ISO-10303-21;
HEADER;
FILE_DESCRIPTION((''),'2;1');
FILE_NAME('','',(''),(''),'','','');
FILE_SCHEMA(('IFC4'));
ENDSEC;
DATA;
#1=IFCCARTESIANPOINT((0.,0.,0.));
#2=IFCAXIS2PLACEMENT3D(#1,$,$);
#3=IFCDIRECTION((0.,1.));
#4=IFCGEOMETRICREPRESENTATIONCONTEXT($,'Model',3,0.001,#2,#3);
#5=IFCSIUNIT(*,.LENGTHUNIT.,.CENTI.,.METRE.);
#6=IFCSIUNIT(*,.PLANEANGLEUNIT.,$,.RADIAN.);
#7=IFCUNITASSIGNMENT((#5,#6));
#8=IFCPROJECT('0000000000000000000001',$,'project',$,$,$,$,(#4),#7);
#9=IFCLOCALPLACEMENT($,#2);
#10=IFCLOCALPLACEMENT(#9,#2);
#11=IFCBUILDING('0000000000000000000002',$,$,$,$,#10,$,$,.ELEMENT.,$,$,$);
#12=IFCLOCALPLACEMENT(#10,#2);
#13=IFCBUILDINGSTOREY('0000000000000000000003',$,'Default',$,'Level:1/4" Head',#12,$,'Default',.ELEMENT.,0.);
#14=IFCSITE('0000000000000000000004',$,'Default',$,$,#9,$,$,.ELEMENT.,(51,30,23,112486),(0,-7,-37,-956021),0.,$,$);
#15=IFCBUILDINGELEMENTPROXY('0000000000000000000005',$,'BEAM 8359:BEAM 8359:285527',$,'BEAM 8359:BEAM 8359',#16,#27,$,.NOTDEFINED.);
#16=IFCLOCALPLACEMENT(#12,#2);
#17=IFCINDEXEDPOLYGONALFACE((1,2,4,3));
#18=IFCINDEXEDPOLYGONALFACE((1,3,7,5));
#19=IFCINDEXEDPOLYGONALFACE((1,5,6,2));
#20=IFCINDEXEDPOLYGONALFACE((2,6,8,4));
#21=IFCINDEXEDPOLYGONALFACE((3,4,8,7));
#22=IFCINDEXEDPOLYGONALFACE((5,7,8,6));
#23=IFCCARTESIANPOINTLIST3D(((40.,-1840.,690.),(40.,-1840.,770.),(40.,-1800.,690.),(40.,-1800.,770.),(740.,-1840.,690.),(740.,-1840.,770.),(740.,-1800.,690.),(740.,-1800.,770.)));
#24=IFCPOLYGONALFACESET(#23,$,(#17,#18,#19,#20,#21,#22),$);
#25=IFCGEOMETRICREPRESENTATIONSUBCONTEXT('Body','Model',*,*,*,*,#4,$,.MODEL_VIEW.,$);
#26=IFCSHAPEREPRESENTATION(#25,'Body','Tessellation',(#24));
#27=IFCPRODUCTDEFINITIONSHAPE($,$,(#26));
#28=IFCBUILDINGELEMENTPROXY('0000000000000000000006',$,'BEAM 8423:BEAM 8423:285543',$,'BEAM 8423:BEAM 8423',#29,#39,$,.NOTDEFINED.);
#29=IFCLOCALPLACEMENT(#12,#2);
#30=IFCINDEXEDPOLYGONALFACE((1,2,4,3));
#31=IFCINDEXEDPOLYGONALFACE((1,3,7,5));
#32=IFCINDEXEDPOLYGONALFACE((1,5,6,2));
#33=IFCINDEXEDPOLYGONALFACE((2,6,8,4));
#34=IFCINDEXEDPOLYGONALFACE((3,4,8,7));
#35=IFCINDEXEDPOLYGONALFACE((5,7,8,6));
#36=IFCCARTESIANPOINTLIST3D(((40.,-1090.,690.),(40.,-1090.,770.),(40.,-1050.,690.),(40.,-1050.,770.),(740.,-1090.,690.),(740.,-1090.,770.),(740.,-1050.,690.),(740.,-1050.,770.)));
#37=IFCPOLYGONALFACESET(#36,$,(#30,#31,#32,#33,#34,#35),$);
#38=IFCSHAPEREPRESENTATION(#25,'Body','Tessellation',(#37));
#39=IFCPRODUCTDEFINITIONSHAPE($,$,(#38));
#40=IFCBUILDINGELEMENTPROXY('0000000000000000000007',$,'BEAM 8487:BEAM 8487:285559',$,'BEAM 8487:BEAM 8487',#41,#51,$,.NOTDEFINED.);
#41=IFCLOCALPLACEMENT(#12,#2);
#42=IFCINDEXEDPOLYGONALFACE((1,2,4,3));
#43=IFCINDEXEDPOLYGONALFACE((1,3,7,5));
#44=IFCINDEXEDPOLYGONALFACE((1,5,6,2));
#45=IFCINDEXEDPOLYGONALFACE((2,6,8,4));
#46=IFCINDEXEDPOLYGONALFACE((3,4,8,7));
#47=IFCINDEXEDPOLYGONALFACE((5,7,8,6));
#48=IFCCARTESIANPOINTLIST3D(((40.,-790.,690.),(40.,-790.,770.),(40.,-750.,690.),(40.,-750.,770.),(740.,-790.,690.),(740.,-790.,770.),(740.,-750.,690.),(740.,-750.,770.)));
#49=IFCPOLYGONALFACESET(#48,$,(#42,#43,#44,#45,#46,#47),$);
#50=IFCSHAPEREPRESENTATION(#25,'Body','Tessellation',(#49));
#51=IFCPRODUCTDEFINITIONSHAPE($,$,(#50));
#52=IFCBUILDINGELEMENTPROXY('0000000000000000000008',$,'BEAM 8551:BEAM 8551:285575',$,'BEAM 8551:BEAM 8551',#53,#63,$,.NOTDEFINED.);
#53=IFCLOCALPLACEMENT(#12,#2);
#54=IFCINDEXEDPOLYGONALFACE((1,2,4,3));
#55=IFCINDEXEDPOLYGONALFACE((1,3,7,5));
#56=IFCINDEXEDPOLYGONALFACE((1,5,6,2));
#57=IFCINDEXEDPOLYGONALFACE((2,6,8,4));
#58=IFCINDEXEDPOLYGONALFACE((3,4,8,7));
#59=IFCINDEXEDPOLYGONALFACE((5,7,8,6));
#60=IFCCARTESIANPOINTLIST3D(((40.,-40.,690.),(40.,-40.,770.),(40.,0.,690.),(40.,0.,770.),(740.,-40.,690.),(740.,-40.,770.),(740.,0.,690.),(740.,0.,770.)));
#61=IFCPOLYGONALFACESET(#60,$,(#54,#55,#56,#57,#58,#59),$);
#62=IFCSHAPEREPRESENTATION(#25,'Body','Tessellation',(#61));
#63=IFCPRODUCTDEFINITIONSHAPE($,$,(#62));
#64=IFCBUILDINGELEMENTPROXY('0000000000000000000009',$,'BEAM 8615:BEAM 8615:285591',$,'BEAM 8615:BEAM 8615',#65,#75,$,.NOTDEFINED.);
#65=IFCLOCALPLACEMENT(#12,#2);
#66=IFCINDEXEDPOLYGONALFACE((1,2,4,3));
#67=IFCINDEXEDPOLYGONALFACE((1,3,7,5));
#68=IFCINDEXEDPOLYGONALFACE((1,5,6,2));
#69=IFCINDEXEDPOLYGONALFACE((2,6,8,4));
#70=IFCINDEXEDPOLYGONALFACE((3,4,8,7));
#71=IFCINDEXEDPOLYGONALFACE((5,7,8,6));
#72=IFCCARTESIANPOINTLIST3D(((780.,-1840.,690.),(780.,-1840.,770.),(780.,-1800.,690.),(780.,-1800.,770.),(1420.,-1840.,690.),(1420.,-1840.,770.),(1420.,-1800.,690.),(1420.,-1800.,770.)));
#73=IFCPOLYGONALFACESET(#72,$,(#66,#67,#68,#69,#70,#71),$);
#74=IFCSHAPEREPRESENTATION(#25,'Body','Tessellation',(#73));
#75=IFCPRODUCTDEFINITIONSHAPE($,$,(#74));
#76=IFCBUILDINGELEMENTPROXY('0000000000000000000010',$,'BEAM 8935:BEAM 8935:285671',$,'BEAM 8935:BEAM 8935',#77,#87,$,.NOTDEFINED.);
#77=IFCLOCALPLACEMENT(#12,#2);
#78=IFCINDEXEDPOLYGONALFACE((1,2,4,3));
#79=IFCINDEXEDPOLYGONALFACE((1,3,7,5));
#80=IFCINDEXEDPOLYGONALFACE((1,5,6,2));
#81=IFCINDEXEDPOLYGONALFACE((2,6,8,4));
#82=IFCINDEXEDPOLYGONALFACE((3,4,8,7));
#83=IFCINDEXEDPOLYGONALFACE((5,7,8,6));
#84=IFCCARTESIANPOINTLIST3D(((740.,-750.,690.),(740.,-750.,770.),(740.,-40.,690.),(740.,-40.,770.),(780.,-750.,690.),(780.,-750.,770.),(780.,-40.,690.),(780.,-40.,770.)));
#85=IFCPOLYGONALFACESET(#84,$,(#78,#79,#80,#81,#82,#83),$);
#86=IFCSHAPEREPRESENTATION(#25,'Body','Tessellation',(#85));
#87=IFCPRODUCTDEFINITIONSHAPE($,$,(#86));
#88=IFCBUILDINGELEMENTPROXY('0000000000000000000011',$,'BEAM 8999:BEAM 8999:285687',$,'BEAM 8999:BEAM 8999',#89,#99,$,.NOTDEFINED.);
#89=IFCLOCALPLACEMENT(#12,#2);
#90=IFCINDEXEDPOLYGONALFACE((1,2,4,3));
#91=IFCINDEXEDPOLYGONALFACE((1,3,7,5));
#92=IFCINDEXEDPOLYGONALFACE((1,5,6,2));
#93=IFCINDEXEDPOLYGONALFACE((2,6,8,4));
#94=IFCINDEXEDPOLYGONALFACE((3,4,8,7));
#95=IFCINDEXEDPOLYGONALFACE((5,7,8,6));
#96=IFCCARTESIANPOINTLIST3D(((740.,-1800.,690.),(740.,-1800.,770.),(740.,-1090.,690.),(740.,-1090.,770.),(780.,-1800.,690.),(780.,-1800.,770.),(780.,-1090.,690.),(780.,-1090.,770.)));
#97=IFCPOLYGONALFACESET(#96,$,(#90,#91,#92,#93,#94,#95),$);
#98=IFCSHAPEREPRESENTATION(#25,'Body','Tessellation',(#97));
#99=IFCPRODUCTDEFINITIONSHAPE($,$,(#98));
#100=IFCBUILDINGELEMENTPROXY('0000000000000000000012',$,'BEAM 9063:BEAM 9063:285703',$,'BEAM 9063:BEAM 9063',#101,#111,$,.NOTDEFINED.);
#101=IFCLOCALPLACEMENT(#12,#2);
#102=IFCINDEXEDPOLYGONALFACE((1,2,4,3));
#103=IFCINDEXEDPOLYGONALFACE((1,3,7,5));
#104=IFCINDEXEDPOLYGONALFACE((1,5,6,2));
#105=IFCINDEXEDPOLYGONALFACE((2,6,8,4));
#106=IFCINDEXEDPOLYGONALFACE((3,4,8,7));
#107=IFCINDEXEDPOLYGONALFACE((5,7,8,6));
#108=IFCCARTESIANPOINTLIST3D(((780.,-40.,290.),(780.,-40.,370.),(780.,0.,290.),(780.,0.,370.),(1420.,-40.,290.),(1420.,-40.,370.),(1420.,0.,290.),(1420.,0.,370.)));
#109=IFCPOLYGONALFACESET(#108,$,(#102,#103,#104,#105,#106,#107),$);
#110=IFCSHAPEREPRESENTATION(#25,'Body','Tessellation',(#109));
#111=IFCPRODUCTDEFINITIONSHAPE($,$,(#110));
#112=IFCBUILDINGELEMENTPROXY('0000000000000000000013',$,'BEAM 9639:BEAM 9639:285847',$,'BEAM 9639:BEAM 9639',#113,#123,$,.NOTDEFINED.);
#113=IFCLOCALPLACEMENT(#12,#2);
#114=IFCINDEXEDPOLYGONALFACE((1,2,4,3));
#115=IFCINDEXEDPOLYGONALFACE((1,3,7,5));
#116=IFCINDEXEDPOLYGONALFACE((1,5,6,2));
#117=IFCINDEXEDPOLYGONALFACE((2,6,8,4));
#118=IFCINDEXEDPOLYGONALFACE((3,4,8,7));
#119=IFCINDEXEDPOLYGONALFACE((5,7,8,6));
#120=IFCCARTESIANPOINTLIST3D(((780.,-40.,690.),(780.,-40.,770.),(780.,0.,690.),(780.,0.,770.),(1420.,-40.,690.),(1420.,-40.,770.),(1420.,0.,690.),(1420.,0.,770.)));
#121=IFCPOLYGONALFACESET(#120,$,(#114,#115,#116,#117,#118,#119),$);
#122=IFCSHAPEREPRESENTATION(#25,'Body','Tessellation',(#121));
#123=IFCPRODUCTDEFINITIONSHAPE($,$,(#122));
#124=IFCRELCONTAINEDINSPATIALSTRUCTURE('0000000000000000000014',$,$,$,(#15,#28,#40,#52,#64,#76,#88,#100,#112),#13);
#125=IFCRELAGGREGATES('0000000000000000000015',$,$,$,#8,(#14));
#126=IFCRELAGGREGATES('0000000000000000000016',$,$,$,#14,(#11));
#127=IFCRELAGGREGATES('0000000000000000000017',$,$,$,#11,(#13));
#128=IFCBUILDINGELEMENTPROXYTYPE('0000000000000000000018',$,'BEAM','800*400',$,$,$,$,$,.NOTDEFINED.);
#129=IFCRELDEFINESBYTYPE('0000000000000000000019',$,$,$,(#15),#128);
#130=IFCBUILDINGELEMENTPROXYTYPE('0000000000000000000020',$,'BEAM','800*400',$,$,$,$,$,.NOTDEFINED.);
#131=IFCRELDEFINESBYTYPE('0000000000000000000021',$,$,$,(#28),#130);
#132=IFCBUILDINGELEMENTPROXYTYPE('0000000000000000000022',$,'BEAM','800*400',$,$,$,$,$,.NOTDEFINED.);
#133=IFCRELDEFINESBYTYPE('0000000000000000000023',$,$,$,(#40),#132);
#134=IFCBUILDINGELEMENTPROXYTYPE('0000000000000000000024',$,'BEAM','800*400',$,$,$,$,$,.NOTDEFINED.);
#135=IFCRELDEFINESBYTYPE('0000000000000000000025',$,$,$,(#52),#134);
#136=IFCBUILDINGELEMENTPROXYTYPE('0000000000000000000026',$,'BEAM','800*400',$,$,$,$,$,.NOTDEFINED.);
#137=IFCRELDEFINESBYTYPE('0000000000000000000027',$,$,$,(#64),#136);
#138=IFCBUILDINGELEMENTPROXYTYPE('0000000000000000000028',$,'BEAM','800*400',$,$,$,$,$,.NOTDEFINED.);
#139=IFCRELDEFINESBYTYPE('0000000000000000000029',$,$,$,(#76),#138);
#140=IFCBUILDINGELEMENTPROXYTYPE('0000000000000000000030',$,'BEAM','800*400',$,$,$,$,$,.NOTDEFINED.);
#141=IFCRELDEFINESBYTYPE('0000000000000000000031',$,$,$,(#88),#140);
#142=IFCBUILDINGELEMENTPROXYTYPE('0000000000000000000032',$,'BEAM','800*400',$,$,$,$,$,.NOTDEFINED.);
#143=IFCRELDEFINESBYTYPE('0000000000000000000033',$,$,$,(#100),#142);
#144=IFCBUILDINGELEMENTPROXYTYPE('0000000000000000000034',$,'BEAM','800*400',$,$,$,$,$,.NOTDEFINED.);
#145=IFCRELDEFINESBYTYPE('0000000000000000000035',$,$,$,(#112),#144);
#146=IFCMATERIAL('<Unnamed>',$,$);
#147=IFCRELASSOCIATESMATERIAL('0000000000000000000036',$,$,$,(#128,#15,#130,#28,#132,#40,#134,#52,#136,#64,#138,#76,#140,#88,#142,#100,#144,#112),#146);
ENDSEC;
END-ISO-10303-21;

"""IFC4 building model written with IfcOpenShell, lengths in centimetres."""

from ifc_helpers import new_model, si_unit, direction, frame, origin, origin_2d_with_axis, place, context, subcontext, project, spatial, rectangle, extrude, source, transform, mapped, material, type_object, type_shapes, element, save


model = new_model("IFC4")

# Units and contexts
model_context = context("Model", 3, precision=0.001, world=origin(), true_north=direction((0.0, 1.0)))
body_context = subcontext(model_context, "Body", "Model", "MODEL_VIEW")
ifc_project = project(units=[si_unit("LENGTHUNIT", "METRE", prefix="CENTI"), si_unit("PLANEANGLEUNIT", "RADIAN")], contexts=[model_context])

# Site, building, storey
site_placement = place(None, origin())
site = spatial("IfcSite", under=ifc_project, at=site_placement, Name="Default", CompositionType="ELEMENT", RefLatitude=(51, 30, 23, 112486), RefLongitude=(0, -7, -37, -956021), RefElevation=0.0)
building_placement = place(site_placement, origin())
building = spatial("IfcBuilding", under=site, at=building_placement, CompositionType="ELEMENT")
storey_placement = place(building_placement, origin())
storey = spatial("IfcBuildingStorey", under=building, at=storey_placement, Name="Default", ObjectType="Level:1/4\" Head", LongName="Default", CompositionType="ELEMENT", Elevation=0.0)

# Building element proxies
ifc_material_1 = material(Name="<Unnamed>")
building_element_proxy_type_1 = type_object("IfcBuildingElementProxyType", Name="BEAM", Description="800*400", PredefinedType="NOTDEFINED", material=ifc_material_1)
shared_shape_1 = source(origin(), body_context, "Body", "SweptSolid", [
    extrude(rectangle(XDim=40.0, YDim=700.0, at=origin_2d_with_axis()), frame((350.0, 20.0, 0.0), z_axis=(0.0, 0.0, 1.0), x_axis=(0.0, 1.0, 0.0)), (0.0, 0.0, 1.0), 80.0),
])
type_shapes(building_element_proxy_type_1, [shared_shape_1])
proxy_1_placement = place(storey_placement, frame((40.0, -1840.0, 690.0)))
element("IfcBuildingElementProxy", 1, at=proxy_1_placement, inside=storey, type_object=building_element_proxy_type_1, material=ifc_material_1, Name="BEAM 8359:BEAM 8359:285527", ObjectType="BEAM 8359:BEAM 8359", PredefinedType="NOTDEFINED", context=body_context, shape_type="MappedRepresentation", body=[
    mapped(shared_shape_1, transform((0.0, 0.0, 0.0), scale=1.0)),
])
building_element_proxy_type_2 = type_object("IfcBuildingElementProxyType", Name="BEAM", Description="800*400", PredefinedType="NOTDEFINED", material=ifc_material_1)
shared_shape_2 = source(origin(), body_context, "Body", "SweptSolid", [
    extrude(rectangle(XDim=40.0, YDim=700.0, at=origin_2d_with_axis()), frame((350.0, 20.0, 0.0), z_axis=(0.0, 0.0, 1.0), x_axis=(0.0, 1.0, 0.0)), (0.0, 0.0, 1.0), 80.0),
])
type_shapes(building_element_proxy_type_2, [shared_shape_2])
proxy_2_placement = place(storey_placement, frame((40.0, -1090.0, 690.0)))
element("IfcBuildingElementProxy", 2, at=proxy_2_placement, inside=storey, type_object=building_element_proxy_type_2, material=ifc_material_1, Name="BEAM 8423:BEAM 8423:285543", ObjectType="BEAM 8423:BEAM 8423", PredefinedType="NOTDEFINED", context=body_context, shape_type="MappedRepresentation", body=[
    mapped(shared_shape_2, transform((0.0, 0.0, 0.0), scale=1.0)),
])
building_element_proxy_type_3 = type_object("IfcBuildingElementProxyType", Name="BEAM", Description="800*400", PredefinedType="NOTDEFINED", material=ifc_material_1)
shared_shape_3 = source(origin(), body_context, "Body", "SweptSolid", [
    extrude(rectangle(XDim=40.0, YDim=700.0, at=origin_2d_with_axis()), frame((350.0, 20.0, 0.0), z_axis=(0.0, 0.0, 1.0), x_axis=(0.0, 1.0, 0.0)), (0.0, 0.0, 1.0), 80.0),
])
type_shapes(building_element_proxy_type_3, [shared_shape_3])
proxy_3_placement = place(storey_placement, frame((40.0, -790.0, 690.0)))
element("IfcBuildingElementProxy", 3, at=proxy_3_placement, inside=storey, type_object=building_element_proxy_type_3, material=ifc_material_1, Name="BEAM 8487:BEAM 8487:285559", ObjectType="BEAM 8487:BEAM 8487", PredefinedType="NOTDEFINED", context=body_context, shape_type="MappedRepresentation", body=[
    mapped(shared_shape_3, transform((0.0, 0.0, 0.0), scale=1.0)),
])
building_element_proxy_type_4 = type_object("IfcBuildingElementProxyType", Name="BEAM", Description="800*400", PredefinedType="NOTDEFINED", material=ifc_material_1)
shared_shape_4 = source(origin(), body_context, "Body", "SweptSolid", [
    extrude(rectangle(XDim=40.0, YDim=700.0, at=origin_2d_with_axis()), frame((350.0, 20.0, 0.0), z_axis=(0.0, 0.0, 1.0), x_axis=(0.0, 1.0, 0.0)), (0.0, 0.0, 1.0), 80.0),
])
type_shapes(building_element_proxy_type_4, [shared_shape_4])
proxy_4_placement = place(storey_placement, frame((40.0, -40.0, 690.0)))
element("IfcBuildingElementProxy", 4, at=proxy_4_placement, inside=storey, type_object=building_element_proxy_type_4, material=ifc_material_1, Name="BEAM 8551:BEAM 8551:285575", ObjectType="BEAM 8551:BEAM 8551", PredefinedType="NOTDEFINED", context=body_context, shape_type="MappedRepresentation", body=[
    mapped(shared_shape_4, transform((0.0, 0.0, 0.0), scale=1.0)),
])
building_element_proxy_type_5 = type_object("IfcBuildingElementProxyType", Name="BEAM", Description="800*400", PredefinedType="NOTDEFINED", material=ifc_material_1)
shared_shape_5 = source(origin(), body_context, "Body", "SweptSolid", [
    extrude(rectangle(XDim=40.0, YDim=640.0, at=origin_2d_with_axis()), frame((320.0, 20.0, 0.0), z_axis=(0.0, 0.0, 1.0), x_axis=(0.0, 1.0, 0.0)), (0.0, 0.0, 1.0), 80.0),
])
type_shapes(building_element_proxy_type_5, [shared_shape_5])
proxy_5_placement = place(storey_placement, frame((780.0, -1840.0, 690.0)))
element("IfcBuildingElementProxy", 5, at=proxy_5_placement, inside=storey, type_object=building_element_proxy_type_5, material=ifc_material_1, Name="BEAM 8615:BEAM 8615:285591", ObjectType="BEAM 8615:BEAM 8615", PredefinedType="NOTDEFINED", context=body_context, shape_type="MappedRepresentation", body=[
    mapped(shared_shape_5, transform((0.0, 0.0, 0.0), scale=1.0)),
])
building_element_proxy_type_6 = type_object("IfcBuildingElementProxyType", Name="BEAM", Description="800*400", PredefinedType="NOTDEFINED", material=ifc_material_1)
shared_shape_6 = source(origin(), body_context, "Body", "SweptSolid", [
    extrude(rectangle(XDim=40.0, YDim=710.0, at=origin_2d_with_axis()), frame((20.0, 355.0, 0.0)), (0.0, 0.0, 1.0), 80.0),
])
type_shapes(building_element_proxy_type_6, [shared_shape_6])
proxy_6_placement = place(storey_placement, frame((740.0, -750.0, 690.0)))
element("IfcBuildingElementProxy", 6, at=proxy_6_placement, inside=storey, type_object=building_element_proxy_type_6, material=ifc_material_1, Name="BEAM 8935:BEAM 8935:285671", ObjectType="BEAM 8935:BEAM 8935", PredefinedType="NOTDEFINED", context=body_context, shape_type="MappedRepresentation", body=[
    mapped(shared_shape_6, transform((0.0, 0.0, 0.0), scale=1.0)),
])
building_element_proxy_type_7 = type_object("IfcBuildingElementProxyType", Name="BEAM", Description="800*400", PredefinedType="NOTDEFINED", material=ifc_material_1)
shared_shape_7 = source(origin(), body_context, "Body", "SweptSolid", [
    extrude(rectangle(XDim=40.0, YDim=710.0, at=origin_2d_with_axis()), frame((20.0, 355.0, 0.0)), (0.0, 0.0, 1.0), 80.0),
])
type_shapes(building_element_proxy_type_7, [shared_shape_7])
proxy_7_placement = place(storey_placement, frame((740.0, -1800.0, 690.0)))
element("IfcBuildingElementProxy", 7, at=proxy_7_placement, inside=storey, type_object=building_element_proxy_type_7, material=ifc_material_1, Name="BEAM 8999:BEAM 8999:285687", ObjectType="BEAM 8999:BEAM 8999", PredefinedType="NOTDEFINED", context=body_context, shape_type="MappedRepresentation", body=[
    mapped(shared_shape_7, transform((0.0, 0.0, 0.0), scale=1.0)),
])
building_element_proxy_type_8 = type_object("IfcBuildingElementProxyType", Name="BEAM", Description="800*400", PredefinedType="NOTDEFINED", material=ifc_material_1)
shared_shape_8 = source(origin(), body_context, "Body", "SweptSolid", [
    extrude(rectangle(XDim=40.0, YDim=640.0, at=origin_2d_with_axis()), frame((320.0, 20.0, 0.0), z_axis=(0.0, 0.0, 1.0), x_axis=(0.0, 1.0, 0.0)), (0.0, 0.0, 1.0), 80.0),
])
type_shapes(building_element_proxy_type_8, [shared_shape_8])
proxy_8_placement = place(storey_placement, frame((780.0, -40.0, 290.0)))
element("IfcBuildingElementProxy", 8, at=proxy_8_placement, inside=storey, type_object=building_element_proxy_type_8, material=ifc_material_1, Name="BEAM 9063:BEAM 9063:285703", ObjectType="BEAM 9063:BEAM 9063", PredefinedType="NOTDEFINED", context=body_context, shape_type="MappedRepresentation", body=[
    mapped(shared_shape_8, transform((0.0, 0.0, 0.0), scale=1.0)),
])
building_element_proxy_type_9 = type_object("IfcBuildingElementProxyType", Name="BEAM", Description="800*400", PredefinedType="NOTDEFINED", material=ifc_material_1)
shared_shape_9 = source(origin(), body_context, "Body", "SweptSolid", [
    extrude(rectangle(XDim=40.0, YDim=640.0, at=origin_2d_with_axis()), frame((320.0, 20.0, 0.0), z_axis=(0.0, 0.0, 1.0), x_axis=(0.0, 1.0, 0.0)), (0.0, 0.0, 1.0), 80.0),
])
type_shapes(building_element_proxy_type_9, [shared_shape_9])
proxy_9_placement = place(storey_placement, frame((780.0, -40.0, 690.0)))
element("IfcBuildingElementProxy", 9, at=proxy_9_placement, inside=storey, type_object=building_element_proxy_type_9, material=ifc_material_1, Name="BEAM 9639:BEAM 9639:285847", ObjectType="BEAM 9639:BEAM 9639", PredefinedType="NOTDEFINED", context=body_context, shape_type="MappedRepresentation", body=[
    mapped(shared_shape_9, transform((0.0, 0.0, 0.0), scale=1.0)),
])

save(model, "model.ifc")
